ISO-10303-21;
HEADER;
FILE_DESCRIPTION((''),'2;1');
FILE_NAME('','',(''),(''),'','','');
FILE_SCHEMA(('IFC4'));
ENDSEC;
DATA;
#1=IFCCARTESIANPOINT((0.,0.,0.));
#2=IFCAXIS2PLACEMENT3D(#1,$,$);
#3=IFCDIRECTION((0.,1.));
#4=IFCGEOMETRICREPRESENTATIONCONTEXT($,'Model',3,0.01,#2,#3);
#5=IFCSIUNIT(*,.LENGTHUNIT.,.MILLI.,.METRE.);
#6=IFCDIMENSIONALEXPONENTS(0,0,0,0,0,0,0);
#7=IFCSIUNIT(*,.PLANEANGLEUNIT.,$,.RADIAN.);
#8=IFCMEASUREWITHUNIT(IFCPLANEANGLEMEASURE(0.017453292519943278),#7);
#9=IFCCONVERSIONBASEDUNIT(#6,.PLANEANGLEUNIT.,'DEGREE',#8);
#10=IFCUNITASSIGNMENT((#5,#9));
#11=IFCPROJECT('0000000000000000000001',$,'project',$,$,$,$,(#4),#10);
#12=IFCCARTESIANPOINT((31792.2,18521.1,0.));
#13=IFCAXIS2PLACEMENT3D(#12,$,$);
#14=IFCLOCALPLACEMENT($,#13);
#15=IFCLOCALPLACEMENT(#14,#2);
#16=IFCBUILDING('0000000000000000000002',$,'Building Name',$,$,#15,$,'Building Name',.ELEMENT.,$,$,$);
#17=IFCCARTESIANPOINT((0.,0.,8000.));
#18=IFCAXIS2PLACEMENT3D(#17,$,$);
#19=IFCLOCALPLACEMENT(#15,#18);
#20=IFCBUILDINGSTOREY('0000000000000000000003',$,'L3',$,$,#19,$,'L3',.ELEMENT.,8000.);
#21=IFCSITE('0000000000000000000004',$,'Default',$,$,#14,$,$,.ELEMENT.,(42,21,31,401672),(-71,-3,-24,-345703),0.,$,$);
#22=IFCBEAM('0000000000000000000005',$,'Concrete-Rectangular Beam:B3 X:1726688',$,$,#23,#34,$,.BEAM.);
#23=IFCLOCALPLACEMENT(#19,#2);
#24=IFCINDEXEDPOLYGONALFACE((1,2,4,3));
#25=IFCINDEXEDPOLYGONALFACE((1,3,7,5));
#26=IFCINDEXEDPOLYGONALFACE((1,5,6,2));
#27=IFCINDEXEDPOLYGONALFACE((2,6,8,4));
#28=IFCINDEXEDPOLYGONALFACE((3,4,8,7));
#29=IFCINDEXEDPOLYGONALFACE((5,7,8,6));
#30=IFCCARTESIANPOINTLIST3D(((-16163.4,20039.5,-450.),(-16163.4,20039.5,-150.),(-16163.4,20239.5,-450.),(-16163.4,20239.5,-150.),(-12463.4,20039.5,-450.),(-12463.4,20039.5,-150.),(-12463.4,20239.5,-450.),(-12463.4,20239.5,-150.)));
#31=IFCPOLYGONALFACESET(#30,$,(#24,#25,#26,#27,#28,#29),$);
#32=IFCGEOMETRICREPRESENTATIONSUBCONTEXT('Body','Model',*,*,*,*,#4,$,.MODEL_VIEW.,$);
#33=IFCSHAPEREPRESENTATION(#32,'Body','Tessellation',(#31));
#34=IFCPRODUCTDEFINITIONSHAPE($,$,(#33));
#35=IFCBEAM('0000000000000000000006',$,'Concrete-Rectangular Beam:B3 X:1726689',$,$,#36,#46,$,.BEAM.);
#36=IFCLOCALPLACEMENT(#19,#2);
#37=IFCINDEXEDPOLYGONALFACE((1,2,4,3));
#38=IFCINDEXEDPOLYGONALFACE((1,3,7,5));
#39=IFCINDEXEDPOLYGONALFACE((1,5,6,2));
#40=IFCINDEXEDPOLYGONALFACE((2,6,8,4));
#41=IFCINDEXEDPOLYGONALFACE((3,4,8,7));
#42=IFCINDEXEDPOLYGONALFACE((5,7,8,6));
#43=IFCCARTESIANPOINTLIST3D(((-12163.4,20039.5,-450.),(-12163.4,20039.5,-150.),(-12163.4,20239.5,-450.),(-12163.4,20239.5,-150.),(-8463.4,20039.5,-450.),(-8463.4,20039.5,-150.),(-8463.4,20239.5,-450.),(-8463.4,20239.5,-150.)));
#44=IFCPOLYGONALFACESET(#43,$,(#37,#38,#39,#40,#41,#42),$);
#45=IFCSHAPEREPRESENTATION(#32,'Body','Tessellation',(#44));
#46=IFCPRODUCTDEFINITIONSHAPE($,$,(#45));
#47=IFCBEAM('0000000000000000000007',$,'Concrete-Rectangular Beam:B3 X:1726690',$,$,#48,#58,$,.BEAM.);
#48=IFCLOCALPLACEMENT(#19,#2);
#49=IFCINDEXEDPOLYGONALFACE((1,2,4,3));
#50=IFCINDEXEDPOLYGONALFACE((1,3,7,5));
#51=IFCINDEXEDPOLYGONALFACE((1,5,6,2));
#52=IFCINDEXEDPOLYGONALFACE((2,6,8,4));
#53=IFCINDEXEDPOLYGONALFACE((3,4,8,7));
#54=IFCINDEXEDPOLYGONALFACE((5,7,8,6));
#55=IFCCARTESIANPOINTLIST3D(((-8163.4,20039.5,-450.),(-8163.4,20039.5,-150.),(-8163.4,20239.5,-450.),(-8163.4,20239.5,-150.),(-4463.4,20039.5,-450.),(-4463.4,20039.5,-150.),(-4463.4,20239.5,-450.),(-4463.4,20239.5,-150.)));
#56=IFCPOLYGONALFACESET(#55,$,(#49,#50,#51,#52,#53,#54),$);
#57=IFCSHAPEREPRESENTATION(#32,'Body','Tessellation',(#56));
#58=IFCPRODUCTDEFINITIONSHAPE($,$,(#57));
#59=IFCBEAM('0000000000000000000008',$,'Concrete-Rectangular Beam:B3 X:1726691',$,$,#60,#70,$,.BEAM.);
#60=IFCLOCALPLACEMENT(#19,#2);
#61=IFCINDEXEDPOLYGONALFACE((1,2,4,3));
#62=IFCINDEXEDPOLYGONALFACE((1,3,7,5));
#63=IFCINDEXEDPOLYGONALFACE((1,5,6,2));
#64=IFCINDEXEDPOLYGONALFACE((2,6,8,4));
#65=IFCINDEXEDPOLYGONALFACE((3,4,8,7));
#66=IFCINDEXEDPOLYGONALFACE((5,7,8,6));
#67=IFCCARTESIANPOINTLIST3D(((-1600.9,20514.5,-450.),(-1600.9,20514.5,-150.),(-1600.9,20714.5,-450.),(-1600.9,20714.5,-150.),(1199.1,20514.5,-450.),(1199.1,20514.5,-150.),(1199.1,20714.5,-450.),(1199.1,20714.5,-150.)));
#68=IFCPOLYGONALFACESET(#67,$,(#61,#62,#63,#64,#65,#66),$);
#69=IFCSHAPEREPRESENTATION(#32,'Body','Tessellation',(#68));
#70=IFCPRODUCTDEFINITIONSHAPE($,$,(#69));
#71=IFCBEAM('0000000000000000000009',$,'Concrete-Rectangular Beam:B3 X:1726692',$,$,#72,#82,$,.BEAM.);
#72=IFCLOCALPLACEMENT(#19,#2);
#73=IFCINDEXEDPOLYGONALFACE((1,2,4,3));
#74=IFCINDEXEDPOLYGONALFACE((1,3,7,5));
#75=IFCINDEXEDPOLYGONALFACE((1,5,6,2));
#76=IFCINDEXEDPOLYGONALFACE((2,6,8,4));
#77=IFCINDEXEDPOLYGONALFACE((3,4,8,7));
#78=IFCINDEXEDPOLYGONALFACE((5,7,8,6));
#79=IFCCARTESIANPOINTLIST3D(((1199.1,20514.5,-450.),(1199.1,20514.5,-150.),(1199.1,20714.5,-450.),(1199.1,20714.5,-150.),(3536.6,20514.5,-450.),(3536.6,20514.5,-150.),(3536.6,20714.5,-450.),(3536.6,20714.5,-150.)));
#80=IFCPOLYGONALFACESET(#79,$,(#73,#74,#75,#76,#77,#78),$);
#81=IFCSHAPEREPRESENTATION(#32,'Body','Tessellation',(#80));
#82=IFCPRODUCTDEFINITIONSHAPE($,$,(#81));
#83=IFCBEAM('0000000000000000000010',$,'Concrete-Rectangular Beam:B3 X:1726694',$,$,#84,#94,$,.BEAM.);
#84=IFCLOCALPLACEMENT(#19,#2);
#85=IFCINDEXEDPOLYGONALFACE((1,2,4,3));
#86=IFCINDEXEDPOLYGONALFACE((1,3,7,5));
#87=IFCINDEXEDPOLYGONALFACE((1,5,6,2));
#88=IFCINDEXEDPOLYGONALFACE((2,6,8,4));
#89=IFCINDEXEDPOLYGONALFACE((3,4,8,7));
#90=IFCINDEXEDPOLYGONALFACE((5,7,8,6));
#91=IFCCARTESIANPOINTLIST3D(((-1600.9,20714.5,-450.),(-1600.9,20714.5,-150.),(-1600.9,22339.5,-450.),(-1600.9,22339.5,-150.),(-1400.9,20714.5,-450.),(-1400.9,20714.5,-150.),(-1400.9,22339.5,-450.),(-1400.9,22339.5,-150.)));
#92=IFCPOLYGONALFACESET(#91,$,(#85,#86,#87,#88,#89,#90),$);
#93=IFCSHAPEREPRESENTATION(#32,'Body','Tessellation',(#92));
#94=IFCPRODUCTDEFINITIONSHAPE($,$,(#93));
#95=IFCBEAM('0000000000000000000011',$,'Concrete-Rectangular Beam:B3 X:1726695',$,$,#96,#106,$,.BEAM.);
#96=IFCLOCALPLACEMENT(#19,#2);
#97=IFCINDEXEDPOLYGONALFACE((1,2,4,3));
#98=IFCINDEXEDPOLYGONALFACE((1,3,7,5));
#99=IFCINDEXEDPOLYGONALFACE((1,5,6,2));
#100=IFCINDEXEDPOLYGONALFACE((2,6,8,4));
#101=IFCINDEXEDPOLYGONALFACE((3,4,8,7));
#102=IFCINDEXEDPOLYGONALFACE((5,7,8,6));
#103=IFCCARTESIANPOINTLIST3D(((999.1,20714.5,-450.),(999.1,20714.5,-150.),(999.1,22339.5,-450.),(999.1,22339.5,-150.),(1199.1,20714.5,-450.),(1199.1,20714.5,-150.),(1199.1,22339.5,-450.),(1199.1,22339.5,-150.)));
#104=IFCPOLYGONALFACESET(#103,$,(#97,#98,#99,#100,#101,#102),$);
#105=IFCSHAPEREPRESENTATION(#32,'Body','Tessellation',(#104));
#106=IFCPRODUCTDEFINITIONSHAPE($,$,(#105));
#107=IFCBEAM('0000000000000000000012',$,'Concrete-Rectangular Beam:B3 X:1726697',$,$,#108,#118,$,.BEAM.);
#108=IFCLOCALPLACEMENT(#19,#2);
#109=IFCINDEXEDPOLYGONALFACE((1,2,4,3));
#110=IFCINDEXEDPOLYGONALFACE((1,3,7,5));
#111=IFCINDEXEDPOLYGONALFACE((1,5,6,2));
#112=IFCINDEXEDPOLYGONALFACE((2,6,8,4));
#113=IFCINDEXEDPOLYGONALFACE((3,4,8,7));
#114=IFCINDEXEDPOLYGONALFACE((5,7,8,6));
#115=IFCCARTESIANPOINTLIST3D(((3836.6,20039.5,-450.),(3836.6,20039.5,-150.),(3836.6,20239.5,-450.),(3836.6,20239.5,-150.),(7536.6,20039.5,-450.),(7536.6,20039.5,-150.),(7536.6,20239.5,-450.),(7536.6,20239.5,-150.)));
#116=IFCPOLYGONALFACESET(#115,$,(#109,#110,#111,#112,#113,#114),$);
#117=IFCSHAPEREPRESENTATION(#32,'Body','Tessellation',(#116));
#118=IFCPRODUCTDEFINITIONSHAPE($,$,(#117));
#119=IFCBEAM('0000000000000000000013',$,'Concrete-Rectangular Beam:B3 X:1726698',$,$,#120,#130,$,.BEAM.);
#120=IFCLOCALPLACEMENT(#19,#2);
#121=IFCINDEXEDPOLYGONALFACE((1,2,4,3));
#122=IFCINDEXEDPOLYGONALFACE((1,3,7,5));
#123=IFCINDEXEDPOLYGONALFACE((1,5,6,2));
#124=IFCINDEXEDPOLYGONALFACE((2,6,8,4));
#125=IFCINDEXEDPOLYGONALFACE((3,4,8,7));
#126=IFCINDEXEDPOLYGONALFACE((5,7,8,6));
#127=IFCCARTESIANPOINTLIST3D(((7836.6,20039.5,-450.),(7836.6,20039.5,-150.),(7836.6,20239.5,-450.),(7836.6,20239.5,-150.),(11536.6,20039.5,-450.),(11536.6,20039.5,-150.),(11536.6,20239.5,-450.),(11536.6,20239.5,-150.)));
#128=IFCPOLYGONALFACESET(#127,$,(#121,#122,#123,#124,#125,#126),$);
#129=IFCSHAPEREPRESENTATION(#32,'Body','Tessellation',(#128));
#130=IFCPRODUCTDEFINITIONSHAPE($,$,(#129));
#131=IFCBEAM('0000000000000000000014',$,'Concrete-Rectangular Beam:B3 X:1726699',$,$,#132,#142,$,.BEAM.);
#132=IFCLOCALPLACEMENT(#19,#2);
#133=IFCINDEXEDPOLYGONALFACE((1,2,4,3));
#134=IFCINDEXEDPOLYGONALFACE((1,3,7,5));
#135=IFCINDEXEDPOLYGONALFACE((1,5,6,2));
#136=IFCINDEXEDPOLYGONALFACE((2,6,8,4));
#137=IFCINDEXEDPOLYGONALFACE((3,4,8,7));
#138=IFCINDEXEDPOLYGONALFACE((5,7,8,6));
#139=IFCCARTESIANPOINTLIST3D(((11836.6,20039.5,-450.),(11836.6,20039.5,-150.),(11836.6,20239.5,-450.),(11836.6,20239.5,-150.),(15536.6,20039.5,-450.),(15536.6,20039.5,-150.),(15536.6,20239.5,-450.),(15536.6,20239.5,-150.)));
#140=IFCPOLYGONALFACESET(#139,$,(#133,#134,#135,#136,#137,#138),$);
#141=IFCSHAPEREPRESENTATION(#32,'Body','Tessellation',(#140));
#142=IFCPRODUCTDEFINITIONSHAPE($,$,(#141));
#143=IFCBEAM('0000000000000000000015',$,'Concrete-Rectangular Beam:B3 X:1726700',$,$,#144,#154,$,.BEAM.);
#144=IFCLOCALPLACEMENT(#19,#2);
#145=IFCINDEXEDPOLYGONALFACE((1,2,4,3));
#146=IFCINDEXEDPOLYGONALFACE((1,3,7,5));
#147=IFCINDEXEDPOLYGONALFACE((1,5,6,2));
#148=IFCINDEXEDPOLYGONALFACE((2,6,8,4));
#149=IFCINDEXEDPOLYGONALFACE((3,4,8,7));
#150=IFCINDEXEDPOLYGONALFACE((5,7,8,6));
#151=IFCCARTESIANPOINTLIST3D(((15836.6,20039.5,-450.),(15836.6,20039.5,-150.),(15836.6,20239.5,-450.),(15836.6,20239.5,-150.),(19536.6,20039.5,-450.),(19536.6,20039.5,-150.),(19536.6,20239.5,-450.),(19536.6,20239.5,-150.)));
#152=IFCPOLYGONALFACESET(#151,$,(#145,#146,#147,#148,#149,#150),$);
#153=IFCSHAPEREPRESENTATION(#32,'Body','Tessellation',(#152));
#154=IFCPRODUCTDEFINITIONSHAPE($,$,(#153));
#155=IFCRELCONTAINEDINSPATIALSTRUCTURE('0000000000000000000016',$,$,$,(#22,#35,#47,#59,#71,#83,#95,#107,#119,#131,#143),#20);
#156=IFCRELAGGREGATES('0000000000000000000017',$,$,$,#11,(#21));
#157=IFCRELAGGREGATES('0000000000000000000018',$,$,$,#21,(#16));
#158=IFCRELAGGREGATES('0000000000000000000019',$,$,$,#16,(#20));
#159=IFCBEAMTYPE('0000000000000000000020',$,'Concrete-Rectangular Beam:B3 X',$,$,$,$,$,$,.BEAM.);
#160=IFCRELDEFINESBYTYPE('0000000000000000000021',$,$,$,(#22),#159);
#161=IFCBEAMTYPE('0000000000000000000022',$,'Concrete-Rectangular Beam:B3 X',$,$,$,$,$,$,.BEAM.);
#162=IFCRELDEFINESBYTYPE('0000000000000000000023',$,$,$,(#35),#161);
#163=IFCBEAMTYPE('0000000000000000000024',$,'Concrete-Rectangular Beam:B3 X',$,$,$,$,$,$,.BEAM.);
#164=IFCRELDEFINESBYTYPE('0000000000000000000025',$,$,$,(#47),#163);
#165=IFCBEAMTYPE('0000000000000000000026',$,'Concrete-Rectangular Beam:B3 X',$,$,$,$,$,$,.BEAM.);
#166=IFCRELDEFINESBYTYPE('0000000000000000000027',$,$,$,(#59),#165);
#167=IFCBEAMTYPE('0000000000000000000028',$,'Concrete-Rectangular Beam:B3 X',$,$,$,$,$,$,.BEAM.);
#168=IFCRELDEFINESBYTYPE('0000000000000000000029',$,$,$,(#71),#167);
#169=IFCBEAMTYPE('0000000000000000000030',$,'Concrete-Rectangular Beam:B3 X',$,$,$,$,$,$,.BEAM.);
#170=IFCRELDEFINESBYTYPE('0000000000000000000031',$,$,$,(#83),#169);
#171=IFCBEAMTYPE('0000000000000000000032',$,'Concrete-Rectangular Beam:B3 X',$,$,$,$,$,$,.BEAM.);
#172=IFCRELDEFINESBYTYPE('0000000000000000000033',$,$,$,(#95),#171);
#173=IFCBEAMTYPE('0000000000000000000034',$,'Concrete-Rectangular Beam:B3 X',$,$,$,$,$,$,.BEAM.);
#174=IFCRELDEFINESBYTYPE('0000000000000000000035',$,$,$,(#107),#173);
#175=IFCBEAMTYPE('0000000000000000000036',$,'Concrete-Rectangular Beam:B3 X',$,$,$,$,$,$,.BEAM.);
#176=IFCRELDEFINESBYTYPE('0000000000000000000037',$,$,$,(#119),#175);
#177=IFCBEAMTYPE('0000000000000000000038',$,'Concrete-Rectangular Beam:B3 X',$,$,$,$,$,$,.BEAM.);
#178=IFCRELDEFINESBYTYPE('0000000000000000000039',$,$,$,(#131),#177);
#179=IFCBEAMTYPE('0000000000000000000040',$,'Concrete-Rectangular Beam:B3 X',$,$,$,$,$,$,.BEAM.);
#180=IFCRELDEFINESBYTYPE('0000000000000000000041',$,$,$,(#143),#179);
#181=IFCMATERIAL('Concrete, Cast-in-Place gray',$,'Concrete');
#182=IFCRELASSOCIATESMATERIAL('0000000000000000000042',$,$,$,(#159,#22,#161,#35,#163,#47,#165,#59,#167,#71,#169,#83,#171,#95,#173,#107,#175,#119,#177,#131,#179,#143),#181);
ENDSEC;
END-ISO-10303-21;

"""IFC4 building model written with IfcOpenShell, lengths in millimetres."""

from ifc_helpers import new_model, entity, si_unit, converted_unit, direction, frame, origin, place, context, subcontext, project, spatial, indexed_curve, outline, extrude, source, transform, mapped, material, type_object, type_shapes, element, save


model = new_model("IFC4")

# Units and contexts
model_context = context("Model", 3, precision=0.01, world=origin(), true_north=direction((0.0, 1.0)))
body_context = subcontext(model_context, "Body", "Model", "MODEL_VIEW")
ifc_project = project(units=[si_unit("LENGTHUNIT", "METRE", prefix="MILLI"), converted_unit("PLANEANGLEUNIT", "DEGREE", entity("IfcPlaneAngleMeasure", 0.017453292519943278), si_unit("PLANEANGLEUNIT", "RADIAN"), dimensions=[0, 0, 0, 0, 0, 0, 0])], contexts=[model_context])

# Site, building, storey
site_placement = place(None, frame((31792.2, 18521.1, 0.0)))
site = spatial("IfcSite", under=ifc_project, at=site_placement, Name="Default", CompositionType="ELEMENT", RefLatitude=(42, 21, 31, 401672), RefLongitude=(-71, -3, -24, -345703), RefElevation=0.0)
building_placement = place(site_placement, origin())
building = spatial("IfcBuilding", under=site, at=building_placement, Name="Building Name", LongName="Building Name", CompositionType="ELEMENT")
storey_placement = place(building_placement, frame((0.0, 0.0, 8000.0)))
storey = spatial("IfcBuildingStorey", under=building, at=storey_placement, Name="L3", LongName="L3", CompositionType="ELEMENT", Elevation=8000.0)

# Beams
ifc_material = material(Name="Concrete, Cast-in-Place gray", Category="Concrete")
beam_type_1 = type_object("IfcBeamType", Name="Concrete-Rectangular Beam:B3 X", PredefinedType="BEAM", material=ifc_material)
shared_shape_1 = source(origin(), body_context, "Body", "SweptSolid", [
    extrude(outline(indexed_curve([(-150.0, -100.0), (150.0, -100.0), (150.0, 100.0), (-150.0, 100.0), (-150.0, -100.0)], self_intersect=False)), frame((-16163.4, 20139.5, 7700.0), z_axis=(1.0, 0.0, 0.0), x_axis=(0.0, 0.0, -1.0)), (0.0, 0.0, 1.0), 3700.0),
])
type_shapes(beam_type_1, [shared_shape_1])
beam_1_placement = place(storey_placement, frame((0.0, 0.0, -8000.0)))
element("IfcBeam", 1, at=beam_1_placement, inside=storey, type_object=beam_type_1, material=ifc_material, Name="Concrete-Rectangular Beam:B3 X:1726688", PredefinedType="BEAM", context=body_context, shape_type="MappedRepresentation", body=[
    mapped(shared_shape_1, transform((0.0, 0.0, 0.0), scale=1.0)),
])
beam_type_2 = type_object("IfcBeamType", Name="Concrete-Rectangular Beam:B3 X", PredefinedType="BEAM", material=ifc_material)
shared_shape_2 = source(origin(), body_context, "Body", "SweptSolid", [
    extrude(outline(indexed_curve([(-150.0, -100.0), (150.0, -100.0), (150.0, 100.0), (-150.0, 100.0), (-150.0, -100.0)], self_intersect=False)), frame((-12163.4, 20139.5, 7700.0), z_axis=(1.0, 0.0, 0.0), x_axis=(0.0, 0.0, -1.0)), (0.0, 0.0, 1.0), 3700.0),
])
type_shapes(beam_type_2, [shared_shape_2])
beam_2_placement = place(storey_placement, frame((0.0, 0.0, -8000.0)))
element("IfcBeam", 2, at=beam_2_placement, inside=storey, type_object=beam_type_2, material=ifc_material, Name="Concrete-Rectangular Beam:B3 X:1726689", PredefinedType="BEAM", context=body_context, shape_type="MappedRepresentation", body=[
    mapped(shared_shape_2, transform((0.0, 0.0, 0.0), scale=1.0)),
])
beam_type_3 = type_object("IfcBeamType", Name="Concrete-Rectangular Beam:B3 X", PredefinedType="BEAM", material=ifc_material)
shared_shape_3 = source(origin(), body_context, "Body", "SweptSolid", [
    extrude(outline(indexed_curve([(-150.0, -100.0), (150.0, -100.0), (150.0, 100.0), (-150.0, 100.0), (-150.0, -100.0)], self_intersect=False)), frame((-8163.4, 20139.5, 7700.0), z_axis=(1.0, 0.0, 0.0), x_axis=(0.0, 0.0, -1.0)), (0.0, 0.0, 1.0), 3700.0),
])
type_shapes(beam_type_3, [shared_shape_3])
beam_3_placement = place(storey_placement, frame((0.0, 0.0, -8000.0)))
element("IfcBeam", 3, at=beam_3_placement, inside=storey, type_object=beam_type_3, material=ifc_material, Name="Concrete-Rectangular Beam:B3 X:1726690", PredefinedType="BEAM", context=body_context, shape_type="MappedRepresentation", body=[
    mapped(shared_shape_3, transform((0.0, 0.0, 0.0), scale=1.0)),
])
beam_type_4 = type_object("IfcBeamType", Name="Concrete-Rectangular Beam:B3 X", PredefinedType="BEAM", material=ifc_material)
shared_shape_4 = source(origin(), body_context, "Body", "SweptSolid", [
    extrude(outline(indexed_curve([(-150.0, -100.0), (150.0, -100.0), (150.0, 100.0), (-150.0, 100.0), (-150.0, -100.0)], self_intersect=False)), frame((-1600.9, 20614.5, 7700.0), z_axis=(1.0, 0.0, 0.0), x_axis=(0.0, 0.0, -1.0)), (0.0, 0.0, 1.0), 2800.0),
])
type_shapes(beam_type_4, [shared_shape_4])
beam_4_placement = place(storey_placement, frame((0.0, 0.0, -8000.0)))
element("IfcBeam", 4, at=beam_4_placement, inside=storey, type_object=beam_type_4, material=ifc_material, Name="Concrete-Rectangular Beam:B3 X:1726691", PredefinedType="BEAM", context=body_context, shape_type="MappedRepresentation", body=[
    mapped(shared_shape_4, transform((0.0, 0.0, 0.0), scale=1.0)),
])
beam_type_5 = type_object("IfcBeamType", Name="Concrete-Rectangular Beam:B3 X", PredefinedType="BEAM", material=ifc_material)
shared_shape_5 = source(origin(), body_context, "Body", "SweptSolid", [
    extrude(outline(indexed_curve([(-150.0, -100.0), (150.0, -100.0), (150.0, 100.0), (-150.0, 100.0), (-150.0, -100.0)], self_intersect=False)), frame((1199.1, 20614.5, 7700.0), z_axis=(1.0, 0.0, 0.0), x_axis=(0.0, 0.0, -1.0)), (0.0, 0.0, 1.0), 2337.5),
])
type_shapes(beam_type_5, [shared_shape_5])
beam_5_placement = place(storey_placement, frame((0.0, 0.0, -8000.0)))
element("IfcBeam", 5, at=beam_5_placement, inside=storey, type_object=beam_type_5, material=ifc_material, Name="Concrete-Rectangular Beam:B3 X:1726692", PredefinedType="BEAM", context=body_context, shape_type="MappedRepresentation", body=[
    mapped(shared_shape_5, transform((0.0, 0.0, 0.0), scale=1.0)),
])
beam_type_6 = type_object("IfcBeamType", Name="Concrete-Rectangular Beam:B3 X", PredefinedType="BEAM", material=ifc_material)
shared_shape_6 = source(origin(), body_context, "Body", "SweptSolid", [
    extrude(outline(indexed_curve([(-100.0, -150.0), (100.0, -150.0), (100.0, 150.0), (-100.0, 150.0), (-100.0, -150.0)], self_intersect=False)), frame((-1500.9, 20714.5, 7700.0), z_axis=(0.0, 1.0, 0.0), x_axis=(-1.0, 0.0, 0.0)), (0.0, 0.0, 1.0), 1625.0),
])
type_shapes(beam_type_6, [shared_shape_6])
beam_6_placement = place(storey_placement, frame((0.0, 0.0, -8000.0)))
element("IfcBeam", 6, at=beam_6_placement, inside=storey, type_object=beam_type_6, material=ifc_material, Name="Concrete-Rectangular Beam:B3 X:1726694", PredefinedType="BEAM", context=body_context, shape_type="MappedRepresentation", body=[
    mapped(shared_shape_6, transform((0.0, 0.0, 0.0), scale=1.0)),
])
beam_type_7 = type_object("IfcBeamType", Name="Concrete-Rectangular Beam:B3 X", PredefinedType="BEAM", material=ifc_material)
shared_shape_7 = source(origin(), body_context, "Body", "SweptSolid", [
    extrude(outline(indexed_curve([(-100.0, -150.0), (100.0, -150.0), (100.0, 150.0), (-100.0, 150.0), (-100.0, -150.0)], self_intersect=False)), frame((1099.1, 22339.5, 7700.0), z_axis=(0.0, -1.0, 0.0), x_axis=(-1.0, 0.0, 0.0)), (0.0, 0.0, 1.0), 1625.0),
])
type_shapes(beam_type_7, [shared_shape_7])
beam_7_placement = place(storey_placement, frame((0.0, 0.0, -8000.0)))
element("IfcBeam", 7, at=beam_7_placement, inside=storey, type_object=beam_type_7, material=ifc_material, Name="Concrete-Rectangular Beam:B3 X:1726695", PredefinedType="BEAM", context=body_context, shape_type="MappedRepresentation", body=[
    mapped(shared_shape_7, transform((0.0, 0.0, 0.0), scale=1.0)),
])
beam_type_8 = type_object("IfcBeamType", Name="Concrete-Rectangular Beam:B3 X", PredefinedType="BEAM", material=ifc_material)
shared_shape_8 = source(origin(), body_context, "Body", "SweptSolid", [
    extrude(outline(indexed_curve([(-150.0, -100.0), (150.0, -100.0), (150.0, 100.0), (-150.0, 100.0), (-150.0, -100.0)], self_intersect=False)), frame((3836.6, 20139.5, 7700.0), z_axis=(1.0, 0.0, 0.0), x_axis=(0.0, 0.0, -1.0)), (0.0, 0.0, 1.0), 3700.0),
])
type_shapes(beam_type_8, [shared_shape_8])
beam_8_placement = place(storey_placement, frame((0.0, 0.0, -8000.0)))
element("IfcBeam", 8, at=beam_8_placement, inside=storey, type_object=beam_type_8, material=ifc_material, Name="Concrete-Rectangular Beam:B3 X:1726697", PredefinedType="BEAM", context=body_context, shape_type="MappedRepresentation", body=[
    mapped(shared_shape_8, transform((0.0, 0.0, 0.0), scale=1.0)),
])
beam_type_9 = type_object("IfcBeamType", Name="Concrete-Rectangular Beam:B3 X", PredefinedType="BEAM", material=ifc_material)
shared_shape_9 = source(origin(), body_context, "Body", "SweptSolid", [
    extrude(outline(indexed_curve([(-150.0, -100.0), (150.0, -100.0), (150.0, 100.0), (-150.0, 100.0), (-150.0, -100.0)], self_intersect=False)), frame((7836.6, 20139.5, 7700.0), z_axis=(1.0, 0.0, 0.0), x_axis=(0.0, 0.0, -1.0)), (0.0, 0.0, 1.0), 3700.0),
])
type_shapes(beam_type_9, [shared_shape_9])
beam_9_placement = place(storey_placement, frame((0.0, 0.0, -8000.0)))
element("IfcBeam", 9, at=beam_9_placement, inside=storey, type_object=beam_type_9, material=ifc_material, Name="Concrete-Rectangular Beam:B3 X:1726698", PredefinedType="BEAM", context=body_context, shape_type="MappedRepresentation", body=[
    mapped(shared_shape_9, transform((0.0, 0.0, 0.0), scale=1.0)),
])
beam_type_10 = type_object("IfcBeamType", Name="Concrete-Rectangular Beam:B3 X", PredefinedType="BEAM", material=ifc_material)
shared_shape_10 = source(origin(), body_context, "Body", "SweptSolid", [
    extrude(outline(indexed_curve([(-150.0, -100.0), (150.0, -100.0), (150.0, 100.0), (-150.0, 100.0), (-150.0, -100.0)], self_intersect=False)), frame((11836.6, 20139.5, 7700.0), z_axis=(1.0, 0.0, 0.0), x_axis=(0.0, 0.0, -1.0)), (0.0, 0.0, 1.0), 3700.0),
])
type_shapes(beam_type_10, [shared_shape_10])
beam_10_placement = place(storey_placement, frame((0.0, 0.0, -8000.0)))
element("IfcBeam", 10, at=beam_10_placement, inside=storey, type_object=beam_type_10, material=ifc_material, Name="Concrete-Rectangular Beam:B3 X:1726699", PredefinedType="BEAM", context=body_context, shape_type="MappedRepresentation", body=[
    mapped(shared_shape_10, transform((0.0, 0.0, 0.0), scale=1.0)),
])
beam_type_11 = type_object("IfcBeamType", Name="Concrete-Rectangular Beam:B3 X", PredefinedType="BEAM", material=ifc_material)
shared_shape_11 = source(origin(), body_context, "Body", "SweptSolid", [
    extrude(outline(indexed_curve([(-150.0, -100.0), (150.0, -100.0), (150.0, 100.0), (-150.0, 100.0), (-150.0, -100.0)], self_intersect=False)), frame((15836.6, 20139.5, 7700.0), z_axis=(1.0, 0.0, 0.0), x_axis=(0.0, 0.0, -1.0)), (0.0, 0.0, 1.0), 3700.0),
])
type_shapes(beam_type_11, [shared_shape_11])
beam_11_placement = place(storey_placement, frame((0.0, 0.0, -8000.0)))
element("IfcBeam", 11, at=beam_11_placement, inside=storey, type_object=beam_type_11, material=ifc_material, Name="Concrete-Rectangular Beam:B3 X:1726700", PredefinedType="BEAM", context=body_context, shape_type="MappedRepresentation", body=[
    mapped(shared_shape_11, transform((0.0, 0.0, 0.0), scale=1.0)),
])

save(model, "model.ifc")
